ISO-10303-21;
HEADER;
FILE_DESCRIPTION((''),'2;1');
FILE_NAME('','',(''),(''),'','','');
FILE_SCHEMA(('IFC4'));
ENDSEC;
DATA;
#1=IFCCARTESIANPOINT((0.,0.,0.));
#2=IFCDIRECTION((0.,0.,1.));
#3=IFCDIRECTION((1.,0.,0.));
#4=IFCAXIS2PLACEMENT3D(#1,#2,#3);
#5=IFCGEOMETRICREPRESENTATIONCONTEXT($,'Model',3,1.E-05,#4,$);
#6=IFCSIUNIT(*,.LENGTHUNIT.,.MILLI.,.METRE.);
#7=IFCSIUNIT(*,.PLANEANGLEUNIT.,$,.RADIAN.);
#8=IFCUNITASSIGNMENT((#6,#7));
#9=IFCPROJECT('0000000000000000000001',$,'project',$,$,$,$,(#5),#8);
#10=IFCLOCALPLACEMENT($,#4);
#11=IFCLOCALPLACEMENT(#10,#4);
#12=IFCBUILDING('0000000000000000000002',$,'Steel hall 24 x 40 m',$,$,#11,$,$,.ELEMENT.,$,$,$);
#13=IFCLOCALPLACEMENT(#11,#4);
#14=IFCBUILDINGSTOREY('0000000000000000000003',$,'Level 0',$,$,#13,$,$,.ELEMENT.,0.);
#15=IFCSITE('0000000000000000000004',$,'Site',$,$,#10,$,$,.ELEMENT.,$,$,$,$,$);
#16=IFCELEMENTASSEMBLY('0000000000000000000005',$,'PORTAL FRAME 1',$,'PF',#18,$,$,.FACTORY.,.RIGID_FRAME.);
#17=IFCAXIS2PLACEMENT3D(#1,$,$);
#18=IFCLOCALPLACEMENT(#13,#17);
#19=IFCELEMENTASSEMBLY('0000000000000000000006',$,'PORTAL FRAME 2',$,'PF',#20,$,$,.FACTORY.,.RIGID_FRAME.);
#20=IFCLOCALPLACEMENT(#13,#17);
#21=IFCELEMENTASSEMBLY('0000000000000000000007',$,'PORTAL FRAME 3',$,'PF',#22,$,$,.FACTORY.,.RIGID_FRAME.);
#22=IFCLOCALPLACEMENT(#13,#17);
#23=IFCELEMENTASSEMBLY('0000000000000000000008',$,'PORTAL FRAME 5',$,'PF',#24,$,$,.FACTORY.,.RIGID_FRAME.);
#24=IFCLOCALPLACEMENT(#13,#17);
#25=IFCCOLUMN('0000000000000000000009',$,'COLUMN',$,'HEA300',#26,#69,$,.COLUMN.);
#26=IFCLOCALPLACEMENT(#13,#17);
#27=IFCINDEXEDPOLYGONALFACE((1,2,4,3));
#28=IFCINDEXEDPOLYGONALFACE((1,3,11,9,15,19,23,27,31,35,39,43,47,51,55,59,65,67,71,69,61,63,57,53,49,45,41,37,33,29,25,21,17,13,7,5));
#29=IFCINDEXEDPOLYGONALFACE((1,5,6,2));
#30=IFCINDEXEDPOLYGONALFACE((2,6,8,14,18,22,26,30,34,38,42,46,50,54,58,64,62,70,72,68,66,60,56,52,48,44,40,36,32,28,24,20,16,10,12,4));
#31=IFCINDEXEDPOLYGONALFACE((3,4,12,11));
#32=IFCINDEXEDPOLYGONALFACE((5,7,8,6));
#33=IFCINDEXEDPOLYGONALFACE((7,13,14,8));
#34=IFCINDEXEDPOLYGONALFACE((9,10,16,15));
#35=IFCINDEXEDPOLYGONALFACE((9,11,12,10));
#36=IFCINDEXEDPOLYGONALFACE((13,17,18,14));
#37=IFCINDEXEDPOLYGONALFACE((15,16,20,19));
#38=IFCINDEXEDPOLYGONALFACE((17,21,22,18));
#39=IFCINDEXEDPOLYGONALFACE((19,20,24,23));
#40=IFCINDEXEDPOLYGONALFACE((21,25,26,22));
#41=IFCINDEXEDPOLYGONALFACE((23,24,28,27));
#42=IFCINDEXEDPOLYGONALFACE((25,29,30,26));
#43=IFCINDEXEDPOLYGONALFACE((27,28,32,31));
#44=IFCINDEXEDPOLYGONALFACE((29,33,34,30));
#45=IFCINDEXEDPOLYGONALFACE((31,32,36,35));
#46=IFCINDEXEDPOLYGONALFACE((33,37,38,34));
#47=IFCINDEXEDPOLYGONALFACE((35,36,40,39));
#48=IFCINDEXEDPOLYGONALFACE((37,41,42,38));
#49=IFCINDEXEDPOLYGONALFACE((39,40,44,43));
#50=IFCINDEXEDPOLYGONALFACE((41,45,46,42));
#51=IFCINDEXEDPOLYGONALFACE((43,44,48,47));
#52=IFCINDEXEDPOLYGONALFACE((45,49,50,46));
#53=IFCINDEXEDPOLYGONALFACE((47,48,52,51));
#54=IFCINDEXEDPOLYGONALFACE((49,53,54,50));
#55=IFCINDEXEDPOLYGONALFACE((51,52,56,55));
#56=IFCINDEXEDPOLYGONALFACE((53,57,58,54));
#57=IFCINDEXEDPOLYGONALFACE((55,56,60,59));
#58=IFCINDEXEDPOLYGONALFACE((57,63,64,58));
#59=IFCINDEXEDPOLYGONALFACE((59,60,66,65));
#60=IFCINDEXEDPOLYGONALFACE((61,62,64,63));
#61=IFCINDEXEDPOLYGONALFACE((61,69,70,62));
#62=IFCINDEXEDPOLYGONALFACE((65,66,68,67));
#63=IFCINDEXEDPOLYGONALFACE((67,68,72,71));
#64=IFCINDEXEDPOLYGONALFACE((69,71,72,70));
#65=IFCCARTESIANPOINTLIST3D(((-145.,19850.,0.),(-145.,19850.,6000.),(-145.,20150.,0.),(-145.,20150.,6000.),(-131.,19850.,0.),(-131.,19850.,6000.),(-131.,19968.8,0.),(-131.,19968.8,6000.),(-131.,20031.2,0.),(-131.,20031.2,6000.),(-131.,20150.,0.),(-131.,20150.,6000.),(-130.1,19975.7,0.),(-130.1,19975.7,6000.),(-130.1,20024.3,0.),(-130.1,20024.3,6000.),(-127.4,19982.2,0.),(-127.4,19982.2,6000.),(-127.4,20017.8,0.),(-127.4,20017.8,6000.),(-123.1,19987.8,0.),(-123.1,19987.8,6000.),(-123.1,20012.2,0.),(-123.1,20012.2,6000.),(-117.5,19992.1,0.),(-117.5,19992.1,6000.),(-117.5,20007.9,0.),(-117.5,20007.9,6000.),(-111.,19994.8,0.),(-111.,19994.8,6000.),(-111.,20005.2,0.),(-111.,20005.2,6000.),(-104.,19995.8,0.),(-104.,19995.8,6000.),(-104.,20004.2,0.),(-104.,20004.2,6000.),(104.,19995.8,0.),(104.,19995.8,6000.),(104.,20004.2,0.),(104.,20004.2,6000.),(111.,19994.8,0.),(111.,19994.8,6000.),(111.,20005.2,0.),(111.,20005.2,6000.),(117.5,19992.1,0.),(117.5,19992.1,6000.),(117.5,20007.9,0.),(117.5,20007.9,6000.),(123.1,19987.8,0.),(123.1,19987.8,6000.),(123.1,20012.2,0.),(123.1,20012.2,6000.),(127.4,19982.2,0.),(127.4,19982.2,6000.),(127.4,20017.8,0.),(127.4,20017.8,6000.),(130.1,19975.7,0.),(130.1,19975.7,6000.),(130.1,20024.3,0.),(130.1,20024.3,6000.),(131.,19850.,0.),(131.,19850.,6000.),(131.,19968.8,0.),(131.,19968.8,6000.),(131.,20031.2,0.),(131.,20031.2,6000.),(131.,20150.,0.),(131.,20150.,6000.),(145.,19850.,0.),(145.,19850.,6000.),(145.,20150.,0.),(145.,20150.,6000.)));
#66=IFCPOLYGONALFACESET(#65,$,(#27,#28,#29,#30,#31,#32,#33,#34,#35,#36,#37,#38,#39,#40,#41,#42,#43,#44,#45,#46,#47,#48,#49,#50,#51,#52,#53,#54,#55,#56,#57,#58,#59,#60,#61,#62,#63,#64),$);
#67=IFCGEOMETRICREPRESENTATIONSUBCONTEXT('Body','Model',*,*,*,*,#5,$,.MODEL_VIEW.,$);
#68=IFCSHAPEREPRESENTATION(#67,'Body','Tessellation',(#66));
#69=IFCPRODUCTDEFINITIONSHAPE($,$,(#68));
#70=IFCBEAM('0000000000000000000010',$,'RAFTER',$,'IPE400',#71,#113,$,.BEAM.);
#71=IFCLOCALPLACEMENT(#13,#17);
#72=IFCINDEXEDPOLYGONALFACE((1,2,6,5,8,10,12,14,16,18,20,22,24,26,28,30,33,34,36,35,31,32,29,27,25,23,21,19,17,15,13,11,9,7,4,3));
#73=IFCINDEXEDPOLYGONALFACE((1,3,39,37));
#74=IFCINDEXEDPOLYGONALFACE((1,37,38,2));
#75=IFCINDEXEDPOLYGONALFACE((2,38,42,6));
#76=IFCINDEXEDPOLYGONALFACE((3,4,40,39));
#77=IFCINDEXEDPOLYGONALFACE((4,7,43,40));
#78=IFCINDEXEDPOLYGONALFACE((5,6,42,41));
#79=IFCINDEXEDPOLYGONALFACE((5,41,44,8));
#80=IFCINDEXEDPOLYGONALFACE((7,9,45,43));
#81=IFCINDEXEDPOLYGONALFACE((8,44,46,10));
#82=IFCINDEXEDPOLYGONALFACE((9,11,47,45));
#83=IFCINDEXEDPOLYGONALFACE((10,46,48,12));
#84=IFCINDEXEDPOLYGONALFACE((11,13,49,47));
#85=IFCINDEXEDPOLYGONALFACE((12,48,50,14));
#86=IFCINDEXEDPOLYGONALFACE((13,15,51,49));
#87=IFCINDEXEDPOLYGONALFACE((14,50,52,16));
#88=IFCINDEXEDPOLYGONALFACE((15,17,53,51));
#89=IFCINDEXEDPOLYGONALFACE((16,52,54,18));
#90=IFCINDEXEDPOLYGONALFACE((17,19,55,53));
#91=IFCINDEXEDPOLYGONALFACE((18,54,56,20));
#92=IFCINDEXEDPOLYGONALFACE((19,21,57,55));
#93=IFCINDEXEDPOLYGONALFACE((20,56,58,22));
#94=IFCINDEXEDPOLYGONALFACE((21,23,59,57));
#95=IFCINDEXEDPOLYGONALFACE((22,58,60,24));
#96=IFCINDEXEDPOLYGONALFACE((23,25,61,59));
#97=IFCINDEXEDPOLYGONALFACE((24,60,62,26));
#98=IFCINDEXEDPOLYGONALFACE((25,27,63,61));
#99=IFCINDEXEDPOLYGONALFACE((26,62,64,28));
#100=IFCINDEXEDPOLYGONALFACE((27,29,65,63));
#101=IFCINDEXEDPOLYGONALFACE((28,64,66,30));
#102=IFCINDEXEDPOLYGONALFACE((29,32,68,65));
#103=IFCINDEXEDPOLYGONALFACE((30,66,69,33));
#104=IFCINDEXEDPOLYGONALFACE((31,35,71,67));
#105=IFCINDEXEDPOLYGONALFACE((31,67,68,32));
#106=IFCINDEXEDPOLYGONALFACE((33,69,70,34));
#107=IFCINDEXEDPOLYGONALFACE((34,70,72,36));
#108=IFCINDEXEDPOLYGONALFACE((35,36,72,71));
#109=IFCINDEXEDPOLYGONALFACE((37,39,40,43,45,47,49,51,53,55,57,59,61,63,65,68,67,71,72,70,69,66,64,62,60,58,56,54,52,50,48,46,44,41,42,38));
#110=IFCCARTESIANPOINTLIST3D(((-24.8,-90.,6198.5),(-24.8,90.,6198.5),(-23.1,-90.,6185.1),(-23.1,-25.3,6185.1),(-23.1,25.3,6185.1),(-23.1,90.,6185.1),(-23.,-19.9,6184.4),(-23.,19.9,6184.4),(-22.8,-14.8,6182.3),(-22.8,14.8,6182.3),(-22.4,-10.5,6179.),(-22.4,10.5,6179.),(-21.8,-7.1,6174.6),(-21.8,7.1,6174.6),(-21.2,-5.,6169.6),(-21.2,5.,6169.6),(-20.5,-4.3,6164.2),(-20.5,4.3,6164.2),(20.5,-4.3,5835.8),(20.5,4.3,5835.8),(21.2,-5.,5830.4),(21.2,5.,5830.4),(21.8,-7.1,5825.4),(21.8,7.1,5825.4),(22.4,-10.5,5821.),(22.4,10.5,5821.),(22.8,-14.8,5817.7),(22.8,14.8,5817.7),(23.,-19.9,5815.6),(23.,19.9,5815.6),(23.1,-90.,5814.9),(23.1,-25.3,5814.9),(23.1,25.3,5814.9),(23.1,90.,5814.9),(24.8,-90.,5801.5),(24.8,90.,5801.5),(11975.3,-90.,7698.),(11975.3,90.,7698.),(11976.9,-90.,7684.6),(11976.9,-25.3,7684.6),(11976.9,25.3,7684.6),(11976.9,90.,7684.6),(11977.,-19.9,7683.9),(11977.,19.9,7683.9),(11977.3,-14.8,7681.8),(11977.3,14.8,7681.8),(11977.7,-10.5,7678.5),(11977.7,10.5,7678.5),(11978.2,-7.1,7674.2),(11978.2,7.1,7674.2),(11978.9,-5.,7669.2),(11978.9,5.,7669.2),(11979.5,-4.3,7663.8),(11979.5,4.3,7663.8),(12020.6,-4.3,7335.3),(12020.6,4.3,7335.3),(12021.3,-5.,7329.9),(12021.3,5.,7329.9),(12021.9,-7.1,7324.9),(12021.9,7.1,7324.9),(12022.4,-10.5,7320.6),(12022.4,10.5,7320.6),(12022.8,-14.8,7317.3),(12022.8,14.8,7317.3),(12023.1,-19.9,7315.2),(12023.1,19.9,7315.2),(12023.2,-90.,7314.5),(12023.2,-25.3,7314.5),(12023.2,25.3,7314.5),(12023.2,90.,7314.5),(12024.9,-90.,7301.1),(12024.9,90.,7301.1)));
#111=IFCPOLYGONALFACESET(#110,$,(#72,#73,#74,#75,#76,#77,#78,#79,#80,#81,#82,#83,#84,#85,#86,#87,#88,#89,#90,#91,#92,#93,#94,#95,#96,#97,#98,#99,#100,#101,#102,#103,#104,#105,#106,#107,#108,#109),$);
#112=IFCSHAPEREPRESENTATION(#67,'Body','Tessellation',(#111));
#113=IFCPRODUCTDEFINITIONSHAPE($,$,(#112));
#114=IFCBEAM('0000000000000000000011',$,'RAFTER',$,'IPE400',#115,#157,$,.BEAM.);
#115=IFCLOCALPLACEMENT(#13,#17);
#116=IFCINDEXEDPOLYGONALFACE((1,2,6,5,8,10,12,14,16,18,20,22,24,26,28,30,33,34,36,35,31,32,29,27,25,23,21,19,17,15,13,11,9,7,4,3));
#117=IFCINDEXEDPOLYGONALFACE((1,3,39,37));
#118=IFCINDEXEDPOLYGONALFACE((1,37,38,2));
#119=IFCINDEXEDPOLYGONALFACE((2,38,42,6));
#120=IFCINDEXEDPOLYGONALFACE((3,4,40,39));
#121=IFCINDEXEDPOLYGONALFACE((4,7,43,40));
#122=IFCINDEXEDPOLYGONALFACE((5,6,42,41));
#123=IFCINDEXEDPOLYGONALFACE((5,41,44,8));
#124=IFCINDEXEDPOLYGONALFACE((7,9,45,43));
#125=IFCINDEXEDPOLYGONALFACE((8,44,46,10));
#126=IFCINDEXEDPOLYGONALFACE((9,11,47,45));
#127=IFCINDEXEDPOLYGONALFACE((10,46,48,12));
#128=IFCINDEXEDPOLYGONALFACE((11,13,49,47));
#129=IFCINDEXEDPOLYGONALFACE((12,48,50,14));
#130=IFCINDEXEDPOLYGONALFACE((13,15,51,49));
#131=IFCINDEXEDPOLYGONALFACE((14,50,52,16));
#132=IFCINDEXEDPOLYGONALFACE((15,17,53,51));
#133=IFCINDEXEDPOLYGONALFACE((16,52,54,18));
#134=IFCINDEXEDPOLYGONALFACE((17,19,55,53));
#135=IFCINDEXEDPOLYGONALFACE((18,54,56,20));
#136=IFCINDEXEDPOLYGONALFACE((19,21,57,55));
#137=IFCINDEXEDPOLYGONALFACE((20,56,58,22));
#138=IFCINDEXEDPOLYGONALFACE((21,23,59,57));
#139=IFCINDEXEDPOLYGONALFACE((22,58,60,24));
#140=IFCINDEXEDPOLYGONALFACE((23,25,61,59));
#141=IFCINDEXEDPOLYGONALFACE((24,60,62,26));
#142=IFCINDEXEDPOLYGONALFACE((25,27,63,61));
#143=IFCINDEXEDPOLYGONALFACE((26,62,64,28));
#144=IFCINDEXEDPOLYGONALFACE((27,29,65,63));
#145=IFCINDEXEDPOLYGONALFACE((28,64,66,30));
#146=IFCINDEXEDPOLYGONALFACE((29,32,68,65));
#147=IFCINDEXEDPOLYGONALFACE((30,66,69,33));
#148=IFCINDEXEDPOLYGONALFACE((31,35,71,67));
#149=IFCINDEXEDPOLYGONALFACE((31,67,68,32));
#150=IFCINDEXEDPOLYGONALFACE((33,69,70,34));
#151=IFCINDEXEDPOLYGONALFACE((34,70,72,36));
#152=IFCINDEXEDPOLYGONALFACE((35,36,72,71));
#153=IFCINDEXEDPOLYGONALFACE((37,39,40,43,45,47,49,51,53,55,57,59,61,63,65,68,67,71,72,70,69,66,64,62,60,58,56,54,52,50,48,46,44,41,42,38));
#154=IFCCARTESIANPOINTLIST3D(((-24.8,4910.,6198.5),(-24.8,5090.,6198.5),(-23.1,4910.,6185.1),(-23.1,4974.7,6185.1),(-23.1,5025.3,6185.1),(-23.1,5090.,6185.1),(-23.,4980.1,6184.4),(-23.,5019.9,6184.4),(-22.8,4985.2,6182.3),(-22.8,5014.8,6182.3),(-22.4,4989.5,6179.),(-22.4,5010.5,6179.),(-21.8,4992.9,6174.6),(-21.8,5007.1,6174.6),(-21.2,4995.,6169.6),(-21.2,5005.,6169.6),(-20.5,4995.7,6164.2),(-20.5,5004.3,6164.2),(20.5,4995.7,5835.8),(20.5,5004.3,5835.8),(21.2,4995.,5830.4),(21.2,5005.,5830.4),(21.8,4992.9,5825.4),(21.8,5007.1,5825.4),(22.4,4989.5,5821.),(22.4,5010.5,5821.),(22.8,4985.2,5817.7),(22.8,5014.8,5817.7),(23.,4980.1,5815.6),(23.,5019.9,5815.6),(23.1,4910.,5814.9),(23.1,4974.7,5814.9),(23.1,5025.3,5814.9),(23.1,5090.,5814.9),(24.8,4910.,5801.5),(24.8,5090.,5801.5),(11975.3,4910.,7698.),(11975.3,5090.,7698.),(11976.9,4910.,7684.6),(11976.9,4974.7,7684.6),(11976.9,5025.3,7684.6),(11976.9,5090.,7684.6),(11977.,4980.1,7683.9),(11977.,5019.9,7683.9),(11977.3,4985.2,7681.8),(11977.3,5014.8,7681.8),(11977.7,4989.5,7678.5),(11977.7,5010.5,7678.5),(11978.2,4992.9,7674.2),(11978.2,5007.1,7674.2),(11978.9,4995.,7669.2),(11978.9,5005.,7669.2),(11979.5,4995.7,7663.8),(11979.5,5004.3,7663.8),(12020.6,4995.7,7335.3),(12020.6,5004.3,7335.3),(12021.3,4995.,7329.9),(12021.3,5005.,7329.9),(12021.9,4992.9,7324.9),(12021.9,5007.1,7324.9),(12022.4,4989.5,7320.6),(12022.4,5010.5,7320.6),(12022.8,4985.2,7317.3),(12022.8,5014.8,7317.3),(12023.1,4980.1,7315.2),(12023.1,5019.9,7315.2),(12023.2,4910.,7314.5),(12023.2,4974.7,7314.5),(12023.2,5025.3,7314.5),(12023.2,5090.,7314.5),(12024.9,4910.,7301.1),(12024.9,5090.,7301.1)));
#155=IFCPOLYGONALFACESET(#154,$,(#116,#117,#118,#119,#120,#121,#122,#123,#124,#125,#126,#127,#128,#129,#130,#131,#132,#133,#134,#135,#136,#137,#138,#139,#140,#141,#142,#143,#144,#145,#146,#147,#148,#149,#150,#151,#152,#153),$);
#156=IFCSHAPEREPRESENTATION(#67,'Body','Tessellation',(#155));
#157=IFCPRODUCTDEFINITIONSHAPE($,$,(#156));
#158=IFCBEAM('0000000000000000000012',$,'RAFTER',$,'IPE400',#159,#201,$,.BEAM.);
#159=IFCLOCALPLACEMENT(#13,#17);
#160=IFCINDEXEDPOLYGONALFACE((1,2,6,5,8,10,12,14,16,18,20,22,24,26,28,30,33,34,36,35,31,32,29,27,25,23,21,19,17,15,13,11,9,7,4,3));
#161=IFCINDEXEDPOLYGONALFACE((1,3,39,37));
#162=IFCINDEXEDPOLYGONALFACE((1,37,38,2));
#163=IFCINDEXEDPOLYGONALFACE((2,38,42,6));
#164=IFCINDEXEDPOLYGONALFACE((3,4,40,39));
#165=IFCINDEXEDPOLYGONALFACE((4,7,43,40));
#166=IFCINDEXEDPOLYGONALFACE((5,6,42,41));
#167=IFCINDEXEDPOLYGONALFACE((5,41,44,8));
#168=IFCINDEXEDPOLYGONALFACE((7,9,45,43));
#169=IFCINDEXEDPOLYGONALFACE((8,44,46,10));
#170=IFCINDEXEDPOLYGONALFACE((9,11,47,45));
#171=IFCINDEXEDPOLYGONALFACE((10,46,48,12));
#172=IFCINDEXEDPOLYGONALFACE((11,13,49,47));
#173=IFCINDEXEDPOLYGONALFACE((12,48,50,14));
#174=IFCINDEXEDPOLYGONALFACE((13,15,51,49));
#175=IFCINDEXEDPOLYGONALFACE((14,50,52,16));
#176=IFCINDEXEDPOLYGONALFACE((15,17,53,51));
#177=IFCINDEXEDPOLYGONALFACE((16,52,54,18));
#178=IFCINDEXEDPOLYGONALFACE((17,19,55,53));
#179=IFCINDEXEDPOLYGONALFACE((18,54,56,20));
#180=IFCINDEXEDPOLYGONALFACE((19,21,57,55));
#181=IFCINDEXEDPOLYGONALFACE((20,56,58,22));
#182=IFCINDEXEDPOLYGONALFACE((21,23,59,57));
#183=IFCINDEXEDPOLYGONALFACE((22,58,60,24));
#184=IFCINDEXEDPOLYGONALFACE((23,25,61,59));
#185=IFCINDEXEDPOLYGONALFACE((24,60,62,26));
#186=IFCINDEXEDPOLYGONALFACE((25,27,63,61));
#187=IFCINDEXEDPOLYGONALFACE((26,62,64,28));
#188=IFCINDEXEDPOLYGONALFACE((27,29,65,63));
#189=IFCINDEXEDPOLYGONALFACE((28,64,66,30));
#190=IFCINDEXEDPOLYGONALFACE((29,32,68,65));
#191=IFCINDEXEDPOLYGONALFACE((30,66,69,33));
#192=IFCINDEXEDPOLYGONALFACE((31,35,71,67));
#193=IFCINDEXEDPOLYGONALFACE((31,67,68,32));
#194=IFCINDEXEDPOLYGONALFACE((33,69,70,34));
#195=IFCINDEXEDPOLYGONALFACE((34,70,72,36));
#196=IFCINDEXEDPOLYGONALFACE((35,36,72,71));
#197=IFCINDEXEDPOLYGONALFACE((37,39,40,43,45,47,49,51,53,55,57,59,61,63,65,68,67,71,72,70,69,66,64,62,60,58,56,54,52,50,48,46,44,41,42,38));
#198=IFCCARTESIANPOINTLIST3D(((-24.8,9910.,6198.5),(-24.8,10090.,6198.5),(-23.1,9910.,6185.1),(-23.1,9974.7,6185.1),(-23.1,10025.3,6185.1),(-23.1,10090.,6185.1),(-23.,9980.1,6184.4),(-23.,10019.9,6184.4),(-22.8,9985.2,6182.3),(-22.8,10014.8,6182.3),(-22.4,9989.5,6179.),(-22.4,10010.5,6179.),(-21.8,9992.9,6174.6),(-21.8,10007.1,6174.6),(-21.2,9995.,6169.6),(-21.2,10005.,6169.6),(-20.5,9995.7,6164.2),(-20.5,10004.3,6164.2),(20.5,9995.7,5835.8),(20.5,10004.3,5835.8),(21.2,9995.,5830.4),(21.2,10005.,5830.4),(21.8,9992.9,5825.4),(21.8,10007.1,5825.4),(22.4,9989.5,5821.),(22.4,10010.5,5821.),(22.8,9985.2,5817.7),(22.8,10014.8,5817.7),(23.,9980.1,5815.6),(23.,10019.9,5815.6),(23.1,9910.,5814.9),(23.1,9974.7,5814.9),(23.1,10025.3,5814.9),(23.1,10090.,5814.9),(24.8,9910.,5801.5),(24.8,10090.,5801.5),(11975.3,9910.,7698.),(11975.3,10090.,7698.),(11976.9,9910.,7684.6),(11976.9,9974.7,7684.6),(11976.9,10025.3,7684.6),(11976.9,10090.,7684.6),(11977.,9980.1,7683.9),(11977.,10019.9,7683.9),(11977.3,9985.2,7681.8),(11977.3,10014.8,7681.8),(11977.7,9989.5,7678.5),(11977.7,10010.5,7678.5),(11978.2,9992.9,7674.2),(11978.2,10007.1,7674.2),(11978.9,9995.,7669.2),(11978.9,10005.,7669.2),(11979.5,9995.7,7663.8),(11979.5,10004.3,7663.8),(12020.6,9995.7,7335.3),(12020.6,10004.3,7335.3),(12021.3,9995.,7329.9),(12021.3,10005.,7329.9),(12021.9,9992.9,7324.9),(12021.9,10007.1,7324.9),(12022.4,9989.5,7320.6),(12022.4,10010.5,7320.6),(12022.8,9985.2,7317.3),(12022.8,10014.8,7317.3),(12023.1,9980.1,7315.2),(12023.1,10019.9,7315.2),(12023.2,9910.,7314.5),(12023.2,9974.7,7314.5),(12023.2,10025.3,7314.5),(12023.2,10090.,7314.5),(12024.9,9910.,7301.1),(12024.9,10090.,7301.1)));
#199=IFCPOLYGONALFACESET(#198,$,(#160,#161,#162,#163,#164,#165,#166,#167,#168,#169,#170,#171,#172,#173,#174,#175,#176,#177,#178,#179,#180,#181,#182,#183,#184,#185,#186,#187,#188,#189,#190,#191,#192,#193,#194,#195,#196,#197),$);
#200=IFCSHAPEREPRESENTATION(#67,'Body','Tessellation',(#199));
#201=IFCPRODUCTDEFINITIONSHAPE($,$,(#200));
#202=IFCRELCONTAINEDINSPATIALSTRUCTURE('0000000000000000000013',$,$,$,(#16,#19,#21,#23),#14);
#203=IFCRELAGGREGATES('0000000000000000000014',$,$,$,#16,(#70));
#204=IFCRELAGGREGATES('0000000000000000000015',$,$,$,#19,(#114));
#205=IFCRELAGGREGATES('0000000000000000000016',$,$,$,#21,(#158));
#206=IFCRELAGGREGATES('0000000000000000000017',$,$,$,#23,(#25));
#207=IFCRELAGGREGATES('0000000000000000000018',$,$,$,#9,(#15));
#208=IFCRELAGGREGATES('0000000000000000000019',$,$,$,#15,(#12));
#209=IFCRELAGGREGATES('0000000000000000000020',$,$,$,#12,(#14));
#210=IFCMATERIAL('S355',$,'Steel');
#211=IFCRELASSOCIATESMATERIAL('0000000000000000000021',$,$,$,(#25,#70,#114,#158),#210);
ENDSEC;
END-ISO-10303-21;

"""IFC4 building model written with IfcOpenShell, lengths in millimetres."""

from ifc_helpers import new_model, si_unit, frame, origin_with_axes, place, context, subcontext, project, spatial, i_section, extrude, material, element, aggregate, save


model = new_model("IFC4")

# Units and contexts
model_context = context("Model", 3, precision=1e-05, world=origin_with_axes())
body_context = subcontext(model_context, "Body", "Model", "MODEL_VIEW")
ifc_project = project(units=[si_unit("LENGTHUNIT", "METRE", prefix="MILLI"), si_unit("PLANEANGLEUNIT", "RADIAN")], contexts=[model_context])

# Site, building, storey
site_placement = place(None, origin_with_axes())
site = spatial("IfcSite", under=ifc_project, at=site_placement, Name="Site", CompositionType="ELEMENT")
building_placement = place(site_placement, origin_with_axes())
building = spatial("IfcBuilding", under=site, at=building_placement, Name="Steel hall 24 x 40 m", CompositionType="ELEMENT")
storey_placement = place(building_placement, origin_with_axes())
storey = spatial("IfcBuildingStorey", under=building, at=storey_placement, Name="Level 0", CompositionType="ELEMENT", Elevation=0.0)

# Element assemblies, column
assembly_1_placement = place(storey_placement, origin_with_axes())
assembly_1 = element("IfcElementAssembly", 1, at=assembly_1_placement, inside=storey, Name="PORTAL FRAME 1", ObjectType="PF", AssemblyPlace="FACTORY", PredefinedType="RIGID_FRAME")
ifc_material = material(Name="S355", Category="Steel")
assembly_2_placement = place(storey_placement, frame((0.0, 5000.0, 0.0), z_axis=(0.0, 0.0, 1.0), x_axis=(1.0, 0.0, 0.0)))
assembly_2 = element("IfcElementAssembly", 2, at=assembly_2_placement, inside=storey, Name="PORTAL FRAME 2", ObjectType="PF", AssemblyPlace="FACTORY", PredefinedType="RIGID_FRAME")
assembly_3_placement = place(storey_placement, frame((0.0, 10000.0, 0.0), z_axis=(0.0, 0.0, 1.0), x_axis=(1.0, 0.0, 0.0)))
assembly_3 = element("IfcElementAssembly", 3, at=assembly_3_placement, inside=storey, Name="PORTAL FRAME 3", ObjectType="PF", AssemblyPlace="FACTORY", PredefinedType="RIGID_FRAME")
assembly_4_placement = place(storey_placement, frame((0.0, 20000.0, 0.0), z_axis=(0.0, 0.0, 1.0), x_axis=(1.0, 0.0, 0.0)))
assembly_4 = element("IfcElementAssembly", 4, at=assembly_4_placement, inside=storey, Name="PORTAL FRAME 5", ObjectType="PF", AssemblyPlace="FACTORY", PredefinedType="RIGID_FRAME")
column_1_placement = place(storey_placement, frame((0.0, 20000.0, 0.0), z_axis=(0.0, 0.0, 1.0), x_axis=(0.0, 1.0, 0.0)))
column_1 = element("IfcColumn", 5, at=column_1_placement, material=ifc_material, Name="COLUMN", ObjectType="HEA300", PredefinedType="COLUMN", context=body_context, shape_type="SweptSolid", body=[
    extrude(i_section(OverallWidth=300.0, OverallDepth=290.0, WebThickness=8.5, FlangeThickness=14.0, FilletRadius=27.0), origin_with_axes(), (0.0, 0.0, 1.0), 6000.0),
])

# Beams
beam_1_placement = place(storey_placement, frame((0.0, 0.0, 6000.0), z_axis=(0.9923, 0.0, 0.124), x_axis=(0.0, 1.0, 0.0)))
beam_1 = element("IfcBeam", 6, at=beam_1_placement, material=ifc_material, Name="RAFTER", ObjectType="IPE400", PredefinedType="BEAM", context=body_context, shape_type="SweptSolid", body=[
    extrude(i_section(OverallWidth=180.0, OverallDepth=400.0, WebThickness=8.6, FlangeThickness=13.5, FilletRadius=21.0), origin_with_axes(), (0.0, 0.0, 1.0), 12093.4),
])
beam_2_placement = place(storey_placement, frame((0.0, 5000.0, 6000.0), z_axis=(0.9923, 0.0, 0.124), x_axis=(0.0, 1.0, 0.0)))
beam_2 = element("IfcBeam", 7, at=beam_2_placement, material=ifc_material, Name="RAFTER", ObjectType="IPE400", PredefinedType="BEAM", context=body_context, shape_type="SweptSolid", body=[
    extrude(i_section(OverallWidth=180.0, OverallDepth=400.0, WebThickness=8.6, FlangeThickness=13.5, FilletRadius=21.0), origin_with_axes(), (0.0, 0.0, 1.0), 12093.4),
])
beam_3_placement = place(storey_placement, frame((0.0, 10000.0, 6000.0), z_axis=(0.9923, 0.0, 0.124), x_axis=(0.0, 1.0, 0.0)))
beam_3 = element("IfcBeam", 8, at=beam_3_placement, material=ifc_material, Name="RAFTER", ObjectType="IPE400", PredefinedType="BEAM", context=body_context, shape_type="SweptSolid", body=[
    extrude(i_section(OverallWidth=180.0, OverallDepth=400.0, WebThickness=8.6, FlangeThickness=13.5, FilletRadius=21.0), origin_with_axes(), (0.0, 0.0, 1.0), 12093.4),
])

aggregate(assembly_1, [beam_1])
aggregate(assembly_2, [beam_2])
aggregate(assembly_3, [beam_3])
aggregate(assembly_4, [column_1])

save(model, "model.ifc")
